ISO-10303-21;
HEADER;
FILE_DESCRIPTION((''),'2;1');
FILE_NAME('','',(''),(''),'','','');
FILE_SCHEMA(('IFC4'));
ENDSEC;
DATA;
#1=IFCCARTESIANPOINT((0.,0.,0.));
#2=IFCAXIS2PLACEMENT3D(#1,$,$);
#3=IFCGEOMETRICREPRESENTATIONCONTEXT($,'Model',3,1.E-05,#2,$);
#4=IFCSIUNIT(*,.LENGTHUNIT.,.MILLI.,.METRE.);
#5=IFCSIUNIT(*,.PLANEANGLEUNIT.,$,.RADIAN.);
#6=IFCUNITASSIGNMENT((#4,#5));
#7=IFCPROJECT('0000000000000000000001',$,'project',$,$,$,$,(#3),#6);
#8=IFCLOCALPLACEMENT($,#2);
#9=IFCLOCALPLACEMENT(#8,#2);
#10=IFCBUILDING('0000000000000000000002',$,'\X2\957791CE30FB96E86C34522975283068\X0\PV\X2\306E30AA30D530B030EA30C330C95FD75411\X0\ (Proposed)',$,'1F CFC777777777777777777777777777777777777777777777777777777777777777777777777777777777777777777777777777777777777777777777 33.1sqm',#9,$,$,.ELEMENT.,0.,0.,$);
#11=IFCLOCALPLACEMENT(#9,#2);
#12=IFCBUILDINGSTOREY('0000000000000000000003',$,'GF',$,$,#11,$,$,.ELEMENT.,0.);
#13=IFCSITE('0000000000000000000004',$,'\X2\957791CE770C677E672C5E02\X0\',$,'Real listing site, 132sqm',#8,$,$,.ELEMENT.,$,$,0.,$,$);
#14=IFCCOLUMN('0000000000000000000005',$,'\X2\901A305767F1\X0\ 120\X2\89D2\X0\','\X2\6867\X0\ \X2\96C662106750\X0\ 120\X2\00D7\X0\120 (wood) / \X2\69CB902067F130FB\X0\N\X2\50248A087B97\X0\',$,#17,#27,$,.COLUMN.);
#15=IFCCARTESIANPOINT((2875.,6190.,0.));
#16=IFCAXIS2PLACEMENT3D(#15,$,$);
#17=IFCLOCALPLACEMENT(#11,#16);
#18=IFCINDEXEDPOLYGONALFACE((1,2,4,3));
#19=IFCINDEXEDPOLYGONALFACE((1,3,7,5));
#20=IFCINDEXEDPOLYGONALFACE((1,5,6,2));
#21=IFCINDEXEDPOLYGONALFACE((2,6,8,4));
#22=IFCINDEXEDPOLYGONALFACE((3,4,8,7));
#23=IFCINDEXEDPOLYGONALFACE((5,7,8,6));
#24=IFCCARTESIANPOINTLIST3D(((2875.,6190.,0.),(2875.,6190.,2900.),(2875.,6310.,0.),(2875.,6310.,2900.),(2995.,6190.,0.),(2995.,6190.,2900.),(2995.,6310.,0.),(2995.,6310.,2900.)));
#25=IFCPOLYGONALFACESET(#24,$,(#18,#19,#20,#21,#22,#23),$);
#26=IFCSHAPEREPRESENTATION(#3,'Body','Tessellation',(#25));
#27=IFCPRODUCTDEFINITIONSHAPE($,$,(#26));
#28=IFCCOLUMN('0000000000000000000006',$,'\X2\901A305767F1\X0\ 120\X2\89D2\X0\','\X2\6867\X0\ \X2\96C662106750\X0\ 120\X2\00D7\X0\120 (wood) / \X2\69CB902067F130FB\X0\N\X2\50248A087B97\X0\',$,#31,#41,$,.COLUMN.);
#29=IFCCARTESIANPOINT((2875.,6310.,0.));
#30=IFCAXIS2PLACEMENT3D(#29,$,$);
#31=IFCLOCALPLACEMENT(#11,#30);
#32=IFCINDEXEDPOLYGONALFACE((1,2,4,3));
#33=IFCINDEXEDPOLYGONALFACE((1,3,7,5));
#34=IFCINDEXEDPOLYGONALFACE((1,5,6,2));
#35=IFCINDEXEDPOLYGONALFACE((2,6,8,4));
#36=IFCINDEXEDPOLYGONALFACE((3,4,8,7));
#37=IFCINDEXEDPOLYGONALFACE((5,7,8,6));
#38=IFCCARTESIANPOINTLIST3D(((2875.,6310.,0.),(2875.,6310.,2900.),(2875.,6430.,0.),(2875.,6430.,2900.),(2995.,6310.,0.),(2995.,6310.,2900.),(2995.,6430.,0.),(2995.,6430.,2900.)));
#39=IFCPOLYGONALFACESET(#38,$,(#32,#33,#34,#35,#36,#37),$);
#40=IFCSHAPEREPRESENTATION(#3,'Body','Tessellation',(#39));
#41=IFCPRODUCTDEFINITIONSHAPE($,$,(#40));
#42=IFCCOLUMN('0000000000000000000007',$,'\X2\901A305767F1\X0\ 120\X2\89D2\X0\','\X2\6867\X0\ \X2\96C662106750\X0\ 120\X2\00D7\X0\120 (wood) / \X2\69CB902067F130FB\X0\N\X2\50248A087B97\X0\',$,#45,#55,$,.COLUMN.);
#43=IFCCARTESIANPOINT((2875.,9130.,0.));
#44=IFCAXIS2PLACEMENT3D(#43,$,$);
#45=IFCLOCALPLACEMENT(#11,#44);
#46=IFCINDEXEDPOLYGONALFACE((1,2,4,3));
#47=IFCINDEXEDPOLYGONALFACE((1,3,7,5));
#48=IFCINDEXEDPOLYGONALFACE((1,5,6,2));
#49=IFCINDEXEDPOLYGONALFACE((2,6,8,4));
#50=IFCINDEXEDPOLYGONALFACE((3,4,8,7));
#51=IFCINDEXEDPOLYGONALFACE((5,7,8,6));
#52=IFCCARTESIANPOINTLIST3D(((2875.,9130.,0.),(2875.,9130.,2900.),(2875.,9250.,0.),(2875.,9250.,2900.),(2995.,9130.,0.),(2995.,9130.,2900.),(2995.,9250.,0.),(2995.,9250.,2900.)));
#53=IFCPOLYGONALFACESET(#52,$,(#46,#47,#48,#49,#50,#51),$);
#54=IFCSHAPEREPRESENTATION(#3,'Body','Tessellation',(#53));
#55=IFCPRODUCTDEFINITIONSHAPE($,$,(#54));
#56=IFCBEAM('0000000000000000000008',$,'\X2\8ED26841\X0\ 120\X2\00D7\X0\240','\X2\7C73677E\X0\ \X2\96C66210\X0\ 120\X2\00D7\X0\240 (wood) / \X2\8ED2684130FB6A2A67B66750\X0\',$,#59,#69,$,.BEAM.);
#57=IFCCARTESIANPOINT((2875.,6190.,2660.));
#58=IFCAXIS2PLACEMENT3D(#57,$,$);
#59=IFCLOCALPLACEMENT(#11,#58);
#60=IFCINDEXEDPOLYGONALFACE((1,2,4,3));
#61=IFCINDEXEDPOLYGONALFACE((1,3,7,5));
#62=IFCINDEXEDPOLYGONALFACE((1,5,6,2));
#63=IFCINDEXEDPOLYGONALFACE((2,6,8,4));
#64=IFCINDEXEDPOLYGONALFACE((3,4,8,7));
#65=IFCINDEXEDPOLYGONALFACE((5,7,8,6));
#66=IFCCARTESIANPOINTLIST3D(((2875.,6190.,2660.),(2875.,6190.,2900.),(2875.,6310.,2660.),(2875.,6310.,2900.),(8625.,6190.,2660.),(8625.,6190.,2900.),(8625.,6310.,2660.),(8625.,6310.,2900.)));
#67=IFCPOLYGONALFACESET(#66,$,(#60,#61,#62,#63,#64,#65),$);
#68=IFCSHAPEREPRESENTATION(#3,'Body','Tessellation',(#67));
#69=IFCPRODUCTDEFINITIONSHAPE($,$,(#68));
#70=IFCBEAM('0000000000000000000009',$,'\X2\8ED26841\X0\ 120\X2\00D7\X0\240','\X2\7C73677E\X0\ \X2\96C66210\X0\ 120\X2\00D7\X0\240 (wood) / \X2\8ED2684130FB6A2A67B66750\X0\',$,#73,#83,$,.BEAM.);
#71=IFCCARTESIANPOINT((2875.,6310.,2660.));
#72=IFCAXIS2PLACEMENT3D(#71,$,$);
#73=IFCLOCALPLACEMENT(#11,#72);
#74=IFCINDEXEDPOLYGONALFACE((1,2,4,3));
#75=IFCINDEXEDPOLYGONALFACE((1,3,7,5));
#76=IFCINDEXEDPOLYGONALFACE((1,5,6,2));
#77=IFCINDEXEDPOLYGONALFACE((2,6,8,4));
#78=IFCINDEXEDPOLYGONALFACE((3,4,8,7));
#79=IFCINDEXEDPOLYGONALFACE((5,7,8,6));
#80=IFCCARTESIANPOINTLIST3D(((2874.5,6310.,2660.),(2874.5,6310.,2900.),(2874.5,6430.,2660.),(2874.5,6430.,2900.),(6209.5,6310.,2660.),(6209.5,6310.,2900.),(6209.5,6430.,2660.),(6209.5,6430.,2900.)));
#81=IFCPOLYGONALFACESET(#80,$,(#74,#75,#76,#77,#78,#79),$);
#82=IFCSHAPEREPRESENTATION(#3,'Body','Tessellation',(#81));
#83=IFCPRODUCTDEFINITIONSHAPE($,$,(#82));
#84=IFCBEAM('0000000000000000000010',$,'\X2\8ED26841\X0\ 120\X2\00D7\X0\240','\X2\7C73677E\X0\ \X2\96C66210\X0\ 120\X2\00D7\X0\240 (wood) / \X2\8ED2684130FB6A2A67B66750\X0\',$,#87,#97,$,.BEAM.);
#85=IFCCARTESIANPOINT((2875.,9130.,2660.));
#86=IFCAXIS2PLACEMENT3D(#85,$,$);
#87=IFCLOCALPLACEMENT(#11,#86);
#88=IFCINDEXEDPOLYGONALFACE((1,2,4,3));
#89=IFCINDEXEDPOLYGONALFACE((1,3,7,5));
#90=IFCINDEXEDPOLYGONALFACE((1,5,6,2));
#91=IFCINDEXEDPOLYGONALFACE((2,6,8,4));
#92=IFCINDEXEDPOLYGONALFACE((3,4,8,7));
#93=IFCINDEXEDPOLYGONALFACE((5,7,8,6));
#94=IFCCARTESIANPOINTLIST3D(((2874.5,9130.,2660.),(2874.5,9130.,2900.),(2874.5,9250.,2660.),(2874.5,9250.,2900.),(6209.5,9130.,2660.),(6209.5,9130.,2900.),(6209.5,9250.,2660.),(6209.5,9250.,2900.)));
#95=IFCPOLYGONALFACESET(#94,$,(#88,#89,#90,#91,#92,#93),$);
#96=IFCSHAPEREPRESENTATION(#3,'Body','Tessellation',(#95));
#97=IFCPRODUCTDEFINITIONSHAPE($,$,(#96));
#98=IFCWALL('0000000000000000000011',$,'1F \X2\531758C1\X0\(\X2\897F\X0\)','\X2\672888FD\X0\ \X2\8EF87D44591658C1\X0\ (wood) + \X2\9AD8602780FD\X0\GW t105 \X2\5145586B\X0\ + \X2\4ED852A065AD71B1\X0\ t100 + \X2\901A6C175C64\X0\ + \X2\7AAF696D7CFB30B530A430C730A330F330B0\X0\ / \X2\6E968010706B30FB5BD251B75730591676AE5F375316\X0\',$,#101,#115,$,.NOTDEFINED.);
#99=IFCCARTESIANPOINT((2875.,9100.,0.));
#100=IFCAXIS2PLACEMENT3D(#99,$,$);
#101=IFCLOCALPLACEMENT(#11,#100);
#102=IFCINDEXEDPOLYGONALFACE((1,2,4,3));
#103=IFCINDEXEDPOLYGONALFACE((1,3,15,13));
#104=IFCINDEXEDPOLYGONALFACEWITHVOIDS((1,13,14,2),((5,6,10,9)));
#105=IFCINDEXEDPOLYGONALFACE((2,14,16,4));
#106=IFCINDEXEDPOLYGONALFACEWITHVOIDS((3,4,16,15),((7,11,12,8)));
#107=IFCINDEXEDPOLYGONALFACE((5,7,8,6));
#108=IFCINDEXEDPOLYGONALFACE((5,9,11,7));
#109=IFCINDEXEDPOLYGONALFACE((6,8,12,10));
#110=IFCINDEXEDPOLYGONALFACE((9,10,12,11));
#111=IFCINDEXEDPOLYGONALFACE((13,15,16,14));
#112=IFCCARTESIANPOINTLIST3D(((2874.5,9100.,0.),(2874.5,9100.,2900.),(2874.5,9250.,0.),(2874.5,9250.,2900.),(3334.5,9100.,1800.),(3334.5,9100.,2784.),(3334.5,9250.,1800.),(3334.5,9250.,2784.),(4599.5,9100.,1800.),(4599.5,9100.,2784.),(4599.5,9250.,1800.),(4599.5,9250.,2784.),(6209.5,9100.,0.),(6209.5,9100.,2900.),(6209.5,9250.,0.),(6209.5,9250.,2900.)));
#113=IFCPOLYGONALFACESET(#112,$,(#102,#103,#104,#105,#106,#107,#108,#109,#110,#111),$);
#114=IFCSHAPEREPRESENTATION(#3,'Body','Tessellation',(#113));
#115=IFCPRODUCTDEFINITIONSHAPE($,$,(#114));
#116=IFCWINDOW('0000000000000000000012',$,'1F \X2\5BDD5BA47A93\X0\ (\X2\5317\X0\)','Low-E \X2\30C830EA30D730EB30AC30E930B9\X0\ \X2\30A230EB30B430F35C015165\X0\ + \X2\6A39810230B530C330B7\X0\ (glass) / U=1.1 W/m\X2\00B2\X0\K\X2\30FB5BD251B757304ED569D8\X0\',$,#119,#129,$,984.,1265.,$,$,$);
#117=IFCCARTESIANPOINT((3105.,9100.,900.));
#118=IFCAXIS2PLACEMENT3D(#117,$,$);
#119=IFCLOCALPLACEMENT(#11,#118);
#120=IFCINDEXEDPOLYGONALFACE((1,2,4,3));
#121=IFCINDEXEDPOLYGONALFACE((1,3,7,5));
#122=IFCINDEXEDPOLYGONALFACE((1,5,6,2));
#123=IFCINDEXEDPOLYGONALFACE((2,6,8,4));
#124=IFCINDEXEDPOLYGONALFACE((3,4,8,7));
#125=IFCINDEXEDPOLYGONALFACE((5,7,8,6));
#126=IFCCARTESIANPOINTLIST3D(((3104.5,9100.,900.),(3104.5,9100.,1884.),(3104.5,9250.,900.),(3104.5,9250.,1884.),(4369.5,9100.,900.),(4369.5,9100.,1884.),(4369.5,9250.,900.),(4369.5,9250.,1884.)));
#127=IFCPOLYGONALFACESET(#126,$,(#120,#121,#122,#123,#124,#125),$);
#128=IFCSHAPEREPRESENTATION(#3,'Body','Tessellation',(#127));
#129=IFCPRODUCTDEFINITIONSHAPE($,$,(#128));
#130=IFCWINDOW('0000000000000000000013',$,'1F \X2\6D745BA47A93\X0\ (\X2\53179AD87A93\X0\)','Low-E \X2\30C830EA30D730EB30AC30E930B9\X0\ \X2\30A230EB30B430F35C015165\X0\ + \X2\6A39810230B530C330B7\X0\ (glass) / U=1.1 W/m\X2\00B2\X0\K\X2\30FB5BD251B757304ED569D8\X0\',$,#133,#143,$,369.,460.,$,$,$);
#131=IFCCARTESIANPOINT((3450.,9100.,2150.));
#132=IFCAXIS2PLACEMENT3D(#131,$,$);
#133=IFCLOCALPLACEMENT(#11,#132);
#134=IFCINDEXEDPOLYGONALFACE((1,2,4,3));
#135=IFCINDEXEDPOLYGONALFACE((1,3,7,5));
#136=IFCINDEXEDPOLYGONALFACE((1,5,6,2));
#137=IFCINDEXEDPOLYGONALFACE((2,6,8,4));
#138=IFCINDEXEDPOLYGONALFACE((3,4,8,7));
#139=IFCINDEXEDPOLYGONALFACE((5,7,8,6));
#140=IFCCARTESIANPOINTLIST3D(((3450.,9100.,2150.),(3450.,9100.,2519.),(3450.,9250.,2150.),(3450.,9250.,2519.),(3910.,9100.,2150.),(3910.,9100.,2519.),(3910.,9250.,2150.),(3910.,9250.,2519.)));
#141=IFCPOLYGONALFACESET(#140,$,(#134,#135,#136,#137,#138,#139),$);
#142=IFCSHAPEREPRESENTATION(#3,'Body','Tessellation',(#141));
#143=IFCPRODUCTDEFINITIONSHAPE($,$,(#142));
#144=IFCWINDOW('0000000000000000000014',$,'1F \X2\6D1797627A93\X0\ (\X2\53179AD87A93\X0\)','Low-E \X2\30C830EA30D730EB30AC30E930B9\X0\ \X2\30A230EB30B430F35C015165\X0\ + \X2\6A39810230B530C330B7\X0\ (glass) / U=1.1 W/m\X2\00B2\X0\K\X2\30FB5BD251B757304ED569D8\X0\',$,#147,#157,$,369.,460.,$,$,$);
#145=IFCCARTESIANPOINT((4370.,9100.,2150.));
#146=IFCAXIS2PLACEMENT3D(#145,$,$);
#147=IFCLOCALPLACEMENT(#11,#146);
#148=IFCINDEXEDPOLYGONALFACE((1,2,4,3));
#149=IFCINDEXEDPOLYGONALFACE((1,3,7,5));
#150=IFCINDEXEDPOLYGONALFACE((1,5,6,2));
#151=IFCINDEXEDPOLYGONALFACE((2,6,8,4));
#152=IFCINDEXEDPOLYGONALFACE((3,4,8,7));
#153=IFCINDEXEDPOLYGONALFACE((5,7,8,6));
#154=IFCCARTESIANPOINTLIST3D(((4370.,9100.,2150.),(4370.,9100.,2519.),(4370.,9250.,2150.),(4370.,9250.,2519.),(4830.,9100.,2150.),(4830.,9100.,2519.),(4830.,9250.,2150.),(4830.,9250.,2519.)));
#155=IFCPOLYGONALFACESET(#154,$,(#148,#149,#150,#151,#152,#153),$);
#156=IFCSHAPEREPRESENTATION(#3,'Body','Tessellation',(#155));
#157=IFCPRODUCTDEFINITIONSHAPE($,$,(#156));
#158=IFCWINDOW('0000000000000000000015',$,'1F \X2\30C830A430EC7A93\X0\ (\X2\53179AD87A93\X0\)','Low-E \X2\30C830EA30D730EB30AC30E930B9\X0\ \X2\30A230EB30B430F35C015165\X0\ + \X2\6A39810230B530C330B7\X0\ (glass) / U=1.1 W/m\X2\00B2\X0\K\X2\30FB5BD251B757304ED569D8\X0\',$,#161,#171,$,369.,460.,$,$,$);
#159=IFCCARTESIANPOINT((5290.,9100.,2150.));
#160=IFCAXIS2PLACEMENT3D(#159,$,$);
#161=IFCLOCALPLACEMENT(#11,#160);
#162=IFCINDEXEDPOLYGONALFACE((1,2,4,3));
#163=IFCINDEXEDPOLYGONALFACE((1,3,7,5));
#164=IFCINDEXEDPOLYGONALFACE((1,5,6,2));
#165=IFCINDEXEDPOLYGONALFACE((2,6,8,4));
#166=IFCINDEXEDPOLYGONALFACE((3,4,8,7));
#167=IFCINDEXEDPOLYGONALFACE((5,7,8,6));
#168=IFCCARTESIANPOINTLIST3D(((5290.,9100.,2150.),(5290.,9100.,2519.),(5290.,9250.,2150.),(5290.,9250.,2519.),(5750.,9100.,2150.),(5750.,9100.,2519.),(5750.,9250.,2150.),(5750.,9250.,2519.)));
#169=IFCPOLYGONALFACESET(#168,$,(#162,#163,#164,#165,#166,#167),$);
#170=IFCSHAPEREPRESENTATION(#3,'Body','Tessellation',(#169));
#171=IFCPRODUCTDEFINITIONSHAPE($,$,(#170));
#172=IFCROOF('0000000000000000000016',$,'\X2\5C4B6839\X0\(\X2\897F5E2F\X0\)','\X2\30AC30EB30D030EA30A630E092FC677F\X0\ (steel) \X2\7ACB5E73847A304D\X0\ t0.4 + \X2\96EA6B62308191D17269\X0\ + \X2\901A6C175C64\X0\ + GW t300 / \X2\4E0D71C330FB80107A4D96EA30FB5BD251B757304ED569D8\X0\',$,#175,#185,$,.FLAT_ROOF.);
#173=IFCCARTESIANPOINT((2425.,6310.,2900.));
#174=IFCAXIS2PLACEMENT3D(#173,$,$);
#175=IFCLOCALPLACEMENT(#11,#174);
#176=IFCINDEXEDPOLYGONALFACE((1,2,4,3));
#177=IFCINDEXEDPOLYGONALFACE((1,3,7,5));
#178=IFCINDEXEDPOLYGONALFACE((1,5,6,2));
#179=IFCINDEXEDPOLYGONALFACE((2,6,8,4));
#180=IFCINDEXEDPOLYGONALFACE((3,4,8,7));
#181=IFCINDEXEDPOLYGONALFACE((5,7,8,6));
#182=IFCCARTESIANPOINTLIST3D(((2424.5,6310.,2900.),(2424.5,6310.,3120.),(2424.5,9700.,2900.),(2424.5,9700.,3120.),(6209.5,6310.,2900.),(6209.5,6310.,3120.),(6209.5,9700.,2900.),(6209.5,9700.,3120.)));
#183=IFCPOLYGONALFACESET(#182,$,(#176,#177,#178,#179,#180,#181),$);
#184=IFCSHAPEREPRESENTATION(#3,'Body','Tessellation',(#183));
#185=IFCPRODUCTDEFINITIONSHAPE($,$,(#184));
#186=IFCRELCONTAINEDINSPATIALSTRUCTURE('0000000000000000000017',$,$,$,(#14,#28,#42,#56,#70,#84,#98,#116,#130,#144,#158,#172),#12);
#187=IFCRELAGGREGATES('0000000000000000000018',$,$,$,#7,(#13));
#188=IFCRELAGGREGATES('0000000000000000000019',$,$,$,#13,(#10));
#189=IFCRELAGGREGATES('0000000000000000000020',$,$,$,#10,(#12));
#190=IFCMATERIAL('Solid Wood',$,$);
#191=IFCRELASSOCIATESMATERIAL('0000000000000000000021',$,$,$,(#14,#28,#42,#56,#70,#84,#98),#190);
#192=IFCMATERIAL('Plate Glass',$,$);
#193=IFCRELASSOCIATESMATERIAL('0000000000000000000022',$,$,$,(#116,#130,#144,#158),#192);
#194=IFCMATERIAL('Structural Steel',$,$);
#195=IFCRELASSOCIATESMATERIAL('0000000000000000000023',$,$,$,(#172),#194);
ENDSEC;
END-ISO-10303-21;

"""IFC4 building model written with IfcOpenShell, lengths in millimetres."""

from ifc_helpers import new_model, si_unit, frame, frame_2d, origin, place, context, project, spatial, rectangle, extrude, material, element, fill, save


model = new_model("IFC4")

# Units and contexts
model_context = context("Model", 3, precision=1e-05, world=origin())
ifc_project = project(units=[si_unit("LENGTHUNIT", "METRE", prefix="MILLI"), si_unit("PLANEANGLEUNIT", "RADIAN")], contexts=[model_context])

# Site, building, storey
site_placement = place(None, origin())
site = spatial("IfcSite", under=ifc_project, at=site_placement, Name="長野県松本市", ObjectType="Real listing site, 132sqm", CompositionType="ELEMENT", RefElevation=0.0)
building_placement = place(site_placement, origin())
building = spatial("IfcBuilding", under=site, at=building_placement, Name="長野・雨水利用とPVのオフグリッド志向 (Proposed)", ObjectType="1F CFC777777777777777777777777777777777777777777777777777777777777777777777777777777777777777777777777777777777777777777777 33.1sqm", CompositionType="ELEMENT", ElevationOfRefHeight=0.0, ElevationOfTerrain=0.0)
storey_placement = place(building_placement, origin())
storey = spatial("IfcBuildingStorey", under=building, at=storey_placement, Name="GF", CompositionType="ELEMENT", Elevation=0.0)

# Columns
ifc_material_1 = material(Name="Solid Wood")
column_1_placement = place(storey_placement, frame((2875.0, 6190.0, 0.0)))
element("IfcColumn", 1, at=column_1_placement, inside=storey, material=ifc_material_1, Name="通し柱 120角", Description="桧 集成材 120×120 (wood) / 構造柱・N値計算", PredefinedType="COLUMN", context=model_context, shape_type="SweptSolid", body=[
    extrude(rectangle(XDim=120.0, YDim=120.0, at=frame_2d((60.0, 60.0))), frame((2875.0, 6190.0, 0.0)), (0.0, 0.0, 1.0), 2900.0),
])
column_2_placement = place(storey_placement, frame((2875.0, 6310.0, 0.0)))
element("IfcColumn", 2, at=column_2_placement, inside=storey, material=ifc_material_1, Name="通し柱 120角", Description="桧 集成材 120×120 (wood) / 構造柱・N値計算", PredefinedType="COLUMN", context=model_context, shape_type="SweptSolid", body=[
    extrude(rectangle(XDim=120.0, YDim=120.0, at=frame_2d((60.0, 60.0))), frame((2875.0, 6310.0, 0.0)), (0.0, 0.0, 1.0), 2900.0),
])
column_3_placement = place(storey_placement, frame((2875.0, 9130.0, 0.0)))
element("IfcColumn", 3, at=column_3_placement, inside=storey, material=ifc_material_1, Name="通し柱 120角", Description="桧 集成材 120×120 (wood) / 構造柱・N値計算", PredefinedType="COLUMN", context=model_context, shape_type="SweptSolid", body=[
    extrude(rectangle(XDim=120.0, YDim=120.0, at=frame_2d((60.0, 60.0))), frame((2875.0, 9130.0, 0.0)), (0.0, 0.0, 1.0), 2900.0),
])

# Beams
beam_1_placement = place(storey_placement, frame((2875.0, 6190.0, 2660.0)))
element("IfcBeam", 4, at=beam_1_placement, inside=storey, material=ifc_material_1, Name="軒桁 120×240", Description="米松 集成 120×240 (wood) / 軒桁・横架材", PredefinedType="BEAM", context=model_context, shape_type="SweptSolid", body=[
    extrude(rectangle(XDim=5750.0, YDim=120.0, at=frame_2d((2875.0, 60.0))), frame((2875.0, 6190.0, 2660.0)), (0.0, 0.0, 1.0), 240.0),
])
beam_2_placement = place(storey_placement, frame((2875.0, 6310.0, 2660.0)))
element("IfcBeam", 5, at=beam_2_placement, inside=storey, material=ifc_material_1, Name="軒桁 120×240", Description="米松 集成 120×240 (wood) / 軒桁・横架材", PredefinedType="BEAM", context=model_context, shape_type="SweptSolid", body=[
    extrude(rectangle(XDim=3335.0, YDim=120.0, at=frame_2d((1667.0, 60.0))), frame((2875.0, 6310.0, 2660.0)), (0.0, 0.0, 1.0), 240.0),
])
beam_3_placement = place(storey_placement, frame((2875.0, 9130.0, 2660.0)))
element("IfcBeam", 6, at=beam_3_placement, inside=storey, material=ifc_material_1, Name="軒桁 120×240", Description="米松 集成 120×240 (wood) / 軒桁・横架材", PredefinedType="BEAM", context=model_context, shape_type="SweptSolid", body=[
    extrude(rectangle(XDim=3335.0, YDim=120.0, at=frame_2d((1667.0, 60.0))), frame((2875.0, 9130.0, 2660.0)), (0.0, 0.0, 1.0), 240.0),
])

# Wall, openings, windows
wall_1_placement = place(storey_placement, frame((2875.0, 9100.0, 0.0)))
wall_1 = element("IfcWall", 7, at=wall_1_placement, inside=storey, material=ifc_material_1, Name="1F 北壁(西)", Description="木製 軸組外壁 (wood) + 高性能GW t105 充填 + 付加断熱 t100 + 通気層 + 窯業系サイディング / 準耐火・寒冷地外皮強化", PredefinedType="NOTDEFINED", context=model_context, shape_type="SweptSolid", body=[
    extrude(rectangle(XDim=3335.0, YDim=150.0, at=frame_2d((1667.0, 75.0))), frame((2875.0, 9100.0, 0.0)), (0.0, 0.0, 1.0), 2900.0),
])
opening_1_placement = place(storey_placement, frame((3105.0, 9100.0, 900.0)))
opening_1 = element("IfcOpeningElement", 8, at=opening_1_placement, cuts=wall_1, PredefinedType="NOTDEFINED", context=model_context, shape_type="SweptSolid", body=[
    extrude(rectangle(XDim=1265.0, YDim=150.0, at=frame_2d((632.0, 75.0))), frame((3105.0, 9100.0, 900.0)), (0.0, 0.0, 1.0), 984.0),
])
opening_2_placement = place(storey_placement, frame((3450.0, 9100.0, 2150.0)))
opening_2 = element("IfcOpeningElement", 9, at=opening_2_placement, cuts=wall_1, PredefinedType="NOTDEFINED", context=model_context, shape_type="SweptSolid", body=[
    extrude(rectangle(XDim=460.0, YDim=150.0, at=frame_2d((230.0, 75.0))), frame((3450.0, 9100.0, 2150.0)), (0.0, 0.0, 1.0), 369.0),
])
opening_3_placement = place(storey_placement, frame((4370.0, 9100.0, 2150.0)))
opening_3 = element("IfcOpeningElement", 10, at=opening_3_placement, cuts=wall_1, PredefinedType="NOTDEFINED", context=model_context, shape_type="SweptSolid", body=[
    extrude(rectangle(XDim=460.0, YDim=150.0, at=frame_2d((230.0, 75.0))), frame((4370.0, 9100.0, 2150.0)), (0.0, 0.0, 1.0), 369.0),
])
opening_4_placement = place(storey_placement, frame((5290.0, 9100.0, 2150.0)))
opening_4 = element("IfcOpeningElement", 11, at=opening_4_placement, cuts=wall_1, PredefinedType="NOTDEFINED", context=model_context, shape_type="SweptSolid", body=[
    extrude(rectangle(XDim=460.0, YDim=150.0, at=frame_2d((230.0, 75.0))), frame((5290.0, 9100.0, 2150.0)), (0.0, 0.0, 1.0), 369.0),
])
ifc_material_2 = material(Name="Plate Glass")
window_1_placement = place(storey_placement, frame((3105.0, 9100.0, 900.0)))
window_1 = element("IfcWindow", 12, at=window_1_placement, inside=storey, material=ifc_material_2, Name="1F 寝室窓 (北)", Description="Low-E トリプルガラス アルゴン封入 + 樹脂サッシ (glass) / U=1.1 W/m²K・寒冷地仕様", OverallHeight=984.0, OverallWidth=1265.0, context=model_context, shape_type="SweptSolid", body=[
    extrude(rectangle(XDim=1265.0, YDim=150.0, at=frame_2d((632.0, 75.0))), frame((3105.0, 9100.0, 900.0)), (0.0, 0.0, 1.0), 984.0),
])
fill(opening_1, window_1)
window_2_placement = place(storey_placement, frame((3450.0, 9100.0, 2150.0)))
window_2 = element("IfcWindow", 13, at=window_2_placement, inside=storey, material=ifc_material_2, Name="1F 浴室窓 (北高窓)", Description="Low-E トリプルガラス アルゴン封入 + 樹脂サッシ (glass) / U=1.1 W/m²K・寒冷地仕様", OverallHeight=369.0, OverallWidth=460.0, context=model_context, shape_type="SweptSolid", body=[
    extrude(rectangle(XDim=460.0, YDim=150.0, at=frame_2d((230.0, 75.0))), frame((3450.0, 9100.0, 2150.0)), (0.0, 0.0, 1.0), 369.0),
])
fill(opening_2, window_2)
window_3_placement = place(storey_placement, frame((4370.0, 9100.0, 2150.0)))
window_3 = element("IfcWindow", 14, at=window_3_placement, inside=storey, material=ifc_material_2, Name="1F 洗面窓 (北高窓)", Description="Low-E トリプルガラス アルゴン封入 + 樹脂サッシ (glass) / U=1.1 W/m²K・寒冷地仕様", OverallHeight=369.0, OverallWidth=460.0, context=model_context, shape_type="SweptSolid", body=[
    extrude(rectangle(XDim=460.0, YDim=150.0, at=frame_2d((230.0, 75.0))), frame((4370.0, 9100.0, 2150.0)), (0.0, 0.0, 1.0), 369.0),
])
fill(opening_3, window_3)
window_4_placement = place(storey_placement, frame((5290.0, 9100.0, 2150.0)))
window_4 = element("IfcWindow", 15, at=window_4_placement, inside=storey, material=ifc_material_2, Name="1F トイレ窓 (北高窓)", Description="Low-E トリプルガラス アルゴン封入 + 樹脂サッシ (glass) / U=1.1 W/m²K・寒冷地仕様", OverallHeight=369.0, OverallWidth=460.0, context=model_context, shape_type="SweptSolid", body=[
    extrude(rectangle(XDim=460.0, YDim=150.0, at=frame_2d((230.0, 75.0))), frame((5290.0, 9100.0, 2150.0)), (0.0, 0.0, 1.0), 369.0),
])
fill(opening_4, window_4)

# Roof
ifc_material_3 = material(Name="Structural Steel")
roof_placement = place(storey_placement, frame((2425.0, 6310.0, 2900.0)))
element("IfcRoof", 16, at=roof_placement, inside=storey, material=ifc_material_3, Name="屋根(西帯)", Description="ガルバリウム鋼板 (steel) 立平葺き t0.4 + 雪止め金物 + 通気層 + GW t300 / 不燃・耐積雪・寒冷地仕様", PredefinedType="FLAT_ROOF", context=model_context, shape_type="SweptSolid", body=[
    extrude(rectangle(XDim=3785.0, YDim=3390.0, at=frame_2d((1892.0, 1695.0))), frame((2425.0, 6310.0, 2900.0)), (0.0, 0.0, 1.0), 220.0),
])

save(model, "model.ifc")
